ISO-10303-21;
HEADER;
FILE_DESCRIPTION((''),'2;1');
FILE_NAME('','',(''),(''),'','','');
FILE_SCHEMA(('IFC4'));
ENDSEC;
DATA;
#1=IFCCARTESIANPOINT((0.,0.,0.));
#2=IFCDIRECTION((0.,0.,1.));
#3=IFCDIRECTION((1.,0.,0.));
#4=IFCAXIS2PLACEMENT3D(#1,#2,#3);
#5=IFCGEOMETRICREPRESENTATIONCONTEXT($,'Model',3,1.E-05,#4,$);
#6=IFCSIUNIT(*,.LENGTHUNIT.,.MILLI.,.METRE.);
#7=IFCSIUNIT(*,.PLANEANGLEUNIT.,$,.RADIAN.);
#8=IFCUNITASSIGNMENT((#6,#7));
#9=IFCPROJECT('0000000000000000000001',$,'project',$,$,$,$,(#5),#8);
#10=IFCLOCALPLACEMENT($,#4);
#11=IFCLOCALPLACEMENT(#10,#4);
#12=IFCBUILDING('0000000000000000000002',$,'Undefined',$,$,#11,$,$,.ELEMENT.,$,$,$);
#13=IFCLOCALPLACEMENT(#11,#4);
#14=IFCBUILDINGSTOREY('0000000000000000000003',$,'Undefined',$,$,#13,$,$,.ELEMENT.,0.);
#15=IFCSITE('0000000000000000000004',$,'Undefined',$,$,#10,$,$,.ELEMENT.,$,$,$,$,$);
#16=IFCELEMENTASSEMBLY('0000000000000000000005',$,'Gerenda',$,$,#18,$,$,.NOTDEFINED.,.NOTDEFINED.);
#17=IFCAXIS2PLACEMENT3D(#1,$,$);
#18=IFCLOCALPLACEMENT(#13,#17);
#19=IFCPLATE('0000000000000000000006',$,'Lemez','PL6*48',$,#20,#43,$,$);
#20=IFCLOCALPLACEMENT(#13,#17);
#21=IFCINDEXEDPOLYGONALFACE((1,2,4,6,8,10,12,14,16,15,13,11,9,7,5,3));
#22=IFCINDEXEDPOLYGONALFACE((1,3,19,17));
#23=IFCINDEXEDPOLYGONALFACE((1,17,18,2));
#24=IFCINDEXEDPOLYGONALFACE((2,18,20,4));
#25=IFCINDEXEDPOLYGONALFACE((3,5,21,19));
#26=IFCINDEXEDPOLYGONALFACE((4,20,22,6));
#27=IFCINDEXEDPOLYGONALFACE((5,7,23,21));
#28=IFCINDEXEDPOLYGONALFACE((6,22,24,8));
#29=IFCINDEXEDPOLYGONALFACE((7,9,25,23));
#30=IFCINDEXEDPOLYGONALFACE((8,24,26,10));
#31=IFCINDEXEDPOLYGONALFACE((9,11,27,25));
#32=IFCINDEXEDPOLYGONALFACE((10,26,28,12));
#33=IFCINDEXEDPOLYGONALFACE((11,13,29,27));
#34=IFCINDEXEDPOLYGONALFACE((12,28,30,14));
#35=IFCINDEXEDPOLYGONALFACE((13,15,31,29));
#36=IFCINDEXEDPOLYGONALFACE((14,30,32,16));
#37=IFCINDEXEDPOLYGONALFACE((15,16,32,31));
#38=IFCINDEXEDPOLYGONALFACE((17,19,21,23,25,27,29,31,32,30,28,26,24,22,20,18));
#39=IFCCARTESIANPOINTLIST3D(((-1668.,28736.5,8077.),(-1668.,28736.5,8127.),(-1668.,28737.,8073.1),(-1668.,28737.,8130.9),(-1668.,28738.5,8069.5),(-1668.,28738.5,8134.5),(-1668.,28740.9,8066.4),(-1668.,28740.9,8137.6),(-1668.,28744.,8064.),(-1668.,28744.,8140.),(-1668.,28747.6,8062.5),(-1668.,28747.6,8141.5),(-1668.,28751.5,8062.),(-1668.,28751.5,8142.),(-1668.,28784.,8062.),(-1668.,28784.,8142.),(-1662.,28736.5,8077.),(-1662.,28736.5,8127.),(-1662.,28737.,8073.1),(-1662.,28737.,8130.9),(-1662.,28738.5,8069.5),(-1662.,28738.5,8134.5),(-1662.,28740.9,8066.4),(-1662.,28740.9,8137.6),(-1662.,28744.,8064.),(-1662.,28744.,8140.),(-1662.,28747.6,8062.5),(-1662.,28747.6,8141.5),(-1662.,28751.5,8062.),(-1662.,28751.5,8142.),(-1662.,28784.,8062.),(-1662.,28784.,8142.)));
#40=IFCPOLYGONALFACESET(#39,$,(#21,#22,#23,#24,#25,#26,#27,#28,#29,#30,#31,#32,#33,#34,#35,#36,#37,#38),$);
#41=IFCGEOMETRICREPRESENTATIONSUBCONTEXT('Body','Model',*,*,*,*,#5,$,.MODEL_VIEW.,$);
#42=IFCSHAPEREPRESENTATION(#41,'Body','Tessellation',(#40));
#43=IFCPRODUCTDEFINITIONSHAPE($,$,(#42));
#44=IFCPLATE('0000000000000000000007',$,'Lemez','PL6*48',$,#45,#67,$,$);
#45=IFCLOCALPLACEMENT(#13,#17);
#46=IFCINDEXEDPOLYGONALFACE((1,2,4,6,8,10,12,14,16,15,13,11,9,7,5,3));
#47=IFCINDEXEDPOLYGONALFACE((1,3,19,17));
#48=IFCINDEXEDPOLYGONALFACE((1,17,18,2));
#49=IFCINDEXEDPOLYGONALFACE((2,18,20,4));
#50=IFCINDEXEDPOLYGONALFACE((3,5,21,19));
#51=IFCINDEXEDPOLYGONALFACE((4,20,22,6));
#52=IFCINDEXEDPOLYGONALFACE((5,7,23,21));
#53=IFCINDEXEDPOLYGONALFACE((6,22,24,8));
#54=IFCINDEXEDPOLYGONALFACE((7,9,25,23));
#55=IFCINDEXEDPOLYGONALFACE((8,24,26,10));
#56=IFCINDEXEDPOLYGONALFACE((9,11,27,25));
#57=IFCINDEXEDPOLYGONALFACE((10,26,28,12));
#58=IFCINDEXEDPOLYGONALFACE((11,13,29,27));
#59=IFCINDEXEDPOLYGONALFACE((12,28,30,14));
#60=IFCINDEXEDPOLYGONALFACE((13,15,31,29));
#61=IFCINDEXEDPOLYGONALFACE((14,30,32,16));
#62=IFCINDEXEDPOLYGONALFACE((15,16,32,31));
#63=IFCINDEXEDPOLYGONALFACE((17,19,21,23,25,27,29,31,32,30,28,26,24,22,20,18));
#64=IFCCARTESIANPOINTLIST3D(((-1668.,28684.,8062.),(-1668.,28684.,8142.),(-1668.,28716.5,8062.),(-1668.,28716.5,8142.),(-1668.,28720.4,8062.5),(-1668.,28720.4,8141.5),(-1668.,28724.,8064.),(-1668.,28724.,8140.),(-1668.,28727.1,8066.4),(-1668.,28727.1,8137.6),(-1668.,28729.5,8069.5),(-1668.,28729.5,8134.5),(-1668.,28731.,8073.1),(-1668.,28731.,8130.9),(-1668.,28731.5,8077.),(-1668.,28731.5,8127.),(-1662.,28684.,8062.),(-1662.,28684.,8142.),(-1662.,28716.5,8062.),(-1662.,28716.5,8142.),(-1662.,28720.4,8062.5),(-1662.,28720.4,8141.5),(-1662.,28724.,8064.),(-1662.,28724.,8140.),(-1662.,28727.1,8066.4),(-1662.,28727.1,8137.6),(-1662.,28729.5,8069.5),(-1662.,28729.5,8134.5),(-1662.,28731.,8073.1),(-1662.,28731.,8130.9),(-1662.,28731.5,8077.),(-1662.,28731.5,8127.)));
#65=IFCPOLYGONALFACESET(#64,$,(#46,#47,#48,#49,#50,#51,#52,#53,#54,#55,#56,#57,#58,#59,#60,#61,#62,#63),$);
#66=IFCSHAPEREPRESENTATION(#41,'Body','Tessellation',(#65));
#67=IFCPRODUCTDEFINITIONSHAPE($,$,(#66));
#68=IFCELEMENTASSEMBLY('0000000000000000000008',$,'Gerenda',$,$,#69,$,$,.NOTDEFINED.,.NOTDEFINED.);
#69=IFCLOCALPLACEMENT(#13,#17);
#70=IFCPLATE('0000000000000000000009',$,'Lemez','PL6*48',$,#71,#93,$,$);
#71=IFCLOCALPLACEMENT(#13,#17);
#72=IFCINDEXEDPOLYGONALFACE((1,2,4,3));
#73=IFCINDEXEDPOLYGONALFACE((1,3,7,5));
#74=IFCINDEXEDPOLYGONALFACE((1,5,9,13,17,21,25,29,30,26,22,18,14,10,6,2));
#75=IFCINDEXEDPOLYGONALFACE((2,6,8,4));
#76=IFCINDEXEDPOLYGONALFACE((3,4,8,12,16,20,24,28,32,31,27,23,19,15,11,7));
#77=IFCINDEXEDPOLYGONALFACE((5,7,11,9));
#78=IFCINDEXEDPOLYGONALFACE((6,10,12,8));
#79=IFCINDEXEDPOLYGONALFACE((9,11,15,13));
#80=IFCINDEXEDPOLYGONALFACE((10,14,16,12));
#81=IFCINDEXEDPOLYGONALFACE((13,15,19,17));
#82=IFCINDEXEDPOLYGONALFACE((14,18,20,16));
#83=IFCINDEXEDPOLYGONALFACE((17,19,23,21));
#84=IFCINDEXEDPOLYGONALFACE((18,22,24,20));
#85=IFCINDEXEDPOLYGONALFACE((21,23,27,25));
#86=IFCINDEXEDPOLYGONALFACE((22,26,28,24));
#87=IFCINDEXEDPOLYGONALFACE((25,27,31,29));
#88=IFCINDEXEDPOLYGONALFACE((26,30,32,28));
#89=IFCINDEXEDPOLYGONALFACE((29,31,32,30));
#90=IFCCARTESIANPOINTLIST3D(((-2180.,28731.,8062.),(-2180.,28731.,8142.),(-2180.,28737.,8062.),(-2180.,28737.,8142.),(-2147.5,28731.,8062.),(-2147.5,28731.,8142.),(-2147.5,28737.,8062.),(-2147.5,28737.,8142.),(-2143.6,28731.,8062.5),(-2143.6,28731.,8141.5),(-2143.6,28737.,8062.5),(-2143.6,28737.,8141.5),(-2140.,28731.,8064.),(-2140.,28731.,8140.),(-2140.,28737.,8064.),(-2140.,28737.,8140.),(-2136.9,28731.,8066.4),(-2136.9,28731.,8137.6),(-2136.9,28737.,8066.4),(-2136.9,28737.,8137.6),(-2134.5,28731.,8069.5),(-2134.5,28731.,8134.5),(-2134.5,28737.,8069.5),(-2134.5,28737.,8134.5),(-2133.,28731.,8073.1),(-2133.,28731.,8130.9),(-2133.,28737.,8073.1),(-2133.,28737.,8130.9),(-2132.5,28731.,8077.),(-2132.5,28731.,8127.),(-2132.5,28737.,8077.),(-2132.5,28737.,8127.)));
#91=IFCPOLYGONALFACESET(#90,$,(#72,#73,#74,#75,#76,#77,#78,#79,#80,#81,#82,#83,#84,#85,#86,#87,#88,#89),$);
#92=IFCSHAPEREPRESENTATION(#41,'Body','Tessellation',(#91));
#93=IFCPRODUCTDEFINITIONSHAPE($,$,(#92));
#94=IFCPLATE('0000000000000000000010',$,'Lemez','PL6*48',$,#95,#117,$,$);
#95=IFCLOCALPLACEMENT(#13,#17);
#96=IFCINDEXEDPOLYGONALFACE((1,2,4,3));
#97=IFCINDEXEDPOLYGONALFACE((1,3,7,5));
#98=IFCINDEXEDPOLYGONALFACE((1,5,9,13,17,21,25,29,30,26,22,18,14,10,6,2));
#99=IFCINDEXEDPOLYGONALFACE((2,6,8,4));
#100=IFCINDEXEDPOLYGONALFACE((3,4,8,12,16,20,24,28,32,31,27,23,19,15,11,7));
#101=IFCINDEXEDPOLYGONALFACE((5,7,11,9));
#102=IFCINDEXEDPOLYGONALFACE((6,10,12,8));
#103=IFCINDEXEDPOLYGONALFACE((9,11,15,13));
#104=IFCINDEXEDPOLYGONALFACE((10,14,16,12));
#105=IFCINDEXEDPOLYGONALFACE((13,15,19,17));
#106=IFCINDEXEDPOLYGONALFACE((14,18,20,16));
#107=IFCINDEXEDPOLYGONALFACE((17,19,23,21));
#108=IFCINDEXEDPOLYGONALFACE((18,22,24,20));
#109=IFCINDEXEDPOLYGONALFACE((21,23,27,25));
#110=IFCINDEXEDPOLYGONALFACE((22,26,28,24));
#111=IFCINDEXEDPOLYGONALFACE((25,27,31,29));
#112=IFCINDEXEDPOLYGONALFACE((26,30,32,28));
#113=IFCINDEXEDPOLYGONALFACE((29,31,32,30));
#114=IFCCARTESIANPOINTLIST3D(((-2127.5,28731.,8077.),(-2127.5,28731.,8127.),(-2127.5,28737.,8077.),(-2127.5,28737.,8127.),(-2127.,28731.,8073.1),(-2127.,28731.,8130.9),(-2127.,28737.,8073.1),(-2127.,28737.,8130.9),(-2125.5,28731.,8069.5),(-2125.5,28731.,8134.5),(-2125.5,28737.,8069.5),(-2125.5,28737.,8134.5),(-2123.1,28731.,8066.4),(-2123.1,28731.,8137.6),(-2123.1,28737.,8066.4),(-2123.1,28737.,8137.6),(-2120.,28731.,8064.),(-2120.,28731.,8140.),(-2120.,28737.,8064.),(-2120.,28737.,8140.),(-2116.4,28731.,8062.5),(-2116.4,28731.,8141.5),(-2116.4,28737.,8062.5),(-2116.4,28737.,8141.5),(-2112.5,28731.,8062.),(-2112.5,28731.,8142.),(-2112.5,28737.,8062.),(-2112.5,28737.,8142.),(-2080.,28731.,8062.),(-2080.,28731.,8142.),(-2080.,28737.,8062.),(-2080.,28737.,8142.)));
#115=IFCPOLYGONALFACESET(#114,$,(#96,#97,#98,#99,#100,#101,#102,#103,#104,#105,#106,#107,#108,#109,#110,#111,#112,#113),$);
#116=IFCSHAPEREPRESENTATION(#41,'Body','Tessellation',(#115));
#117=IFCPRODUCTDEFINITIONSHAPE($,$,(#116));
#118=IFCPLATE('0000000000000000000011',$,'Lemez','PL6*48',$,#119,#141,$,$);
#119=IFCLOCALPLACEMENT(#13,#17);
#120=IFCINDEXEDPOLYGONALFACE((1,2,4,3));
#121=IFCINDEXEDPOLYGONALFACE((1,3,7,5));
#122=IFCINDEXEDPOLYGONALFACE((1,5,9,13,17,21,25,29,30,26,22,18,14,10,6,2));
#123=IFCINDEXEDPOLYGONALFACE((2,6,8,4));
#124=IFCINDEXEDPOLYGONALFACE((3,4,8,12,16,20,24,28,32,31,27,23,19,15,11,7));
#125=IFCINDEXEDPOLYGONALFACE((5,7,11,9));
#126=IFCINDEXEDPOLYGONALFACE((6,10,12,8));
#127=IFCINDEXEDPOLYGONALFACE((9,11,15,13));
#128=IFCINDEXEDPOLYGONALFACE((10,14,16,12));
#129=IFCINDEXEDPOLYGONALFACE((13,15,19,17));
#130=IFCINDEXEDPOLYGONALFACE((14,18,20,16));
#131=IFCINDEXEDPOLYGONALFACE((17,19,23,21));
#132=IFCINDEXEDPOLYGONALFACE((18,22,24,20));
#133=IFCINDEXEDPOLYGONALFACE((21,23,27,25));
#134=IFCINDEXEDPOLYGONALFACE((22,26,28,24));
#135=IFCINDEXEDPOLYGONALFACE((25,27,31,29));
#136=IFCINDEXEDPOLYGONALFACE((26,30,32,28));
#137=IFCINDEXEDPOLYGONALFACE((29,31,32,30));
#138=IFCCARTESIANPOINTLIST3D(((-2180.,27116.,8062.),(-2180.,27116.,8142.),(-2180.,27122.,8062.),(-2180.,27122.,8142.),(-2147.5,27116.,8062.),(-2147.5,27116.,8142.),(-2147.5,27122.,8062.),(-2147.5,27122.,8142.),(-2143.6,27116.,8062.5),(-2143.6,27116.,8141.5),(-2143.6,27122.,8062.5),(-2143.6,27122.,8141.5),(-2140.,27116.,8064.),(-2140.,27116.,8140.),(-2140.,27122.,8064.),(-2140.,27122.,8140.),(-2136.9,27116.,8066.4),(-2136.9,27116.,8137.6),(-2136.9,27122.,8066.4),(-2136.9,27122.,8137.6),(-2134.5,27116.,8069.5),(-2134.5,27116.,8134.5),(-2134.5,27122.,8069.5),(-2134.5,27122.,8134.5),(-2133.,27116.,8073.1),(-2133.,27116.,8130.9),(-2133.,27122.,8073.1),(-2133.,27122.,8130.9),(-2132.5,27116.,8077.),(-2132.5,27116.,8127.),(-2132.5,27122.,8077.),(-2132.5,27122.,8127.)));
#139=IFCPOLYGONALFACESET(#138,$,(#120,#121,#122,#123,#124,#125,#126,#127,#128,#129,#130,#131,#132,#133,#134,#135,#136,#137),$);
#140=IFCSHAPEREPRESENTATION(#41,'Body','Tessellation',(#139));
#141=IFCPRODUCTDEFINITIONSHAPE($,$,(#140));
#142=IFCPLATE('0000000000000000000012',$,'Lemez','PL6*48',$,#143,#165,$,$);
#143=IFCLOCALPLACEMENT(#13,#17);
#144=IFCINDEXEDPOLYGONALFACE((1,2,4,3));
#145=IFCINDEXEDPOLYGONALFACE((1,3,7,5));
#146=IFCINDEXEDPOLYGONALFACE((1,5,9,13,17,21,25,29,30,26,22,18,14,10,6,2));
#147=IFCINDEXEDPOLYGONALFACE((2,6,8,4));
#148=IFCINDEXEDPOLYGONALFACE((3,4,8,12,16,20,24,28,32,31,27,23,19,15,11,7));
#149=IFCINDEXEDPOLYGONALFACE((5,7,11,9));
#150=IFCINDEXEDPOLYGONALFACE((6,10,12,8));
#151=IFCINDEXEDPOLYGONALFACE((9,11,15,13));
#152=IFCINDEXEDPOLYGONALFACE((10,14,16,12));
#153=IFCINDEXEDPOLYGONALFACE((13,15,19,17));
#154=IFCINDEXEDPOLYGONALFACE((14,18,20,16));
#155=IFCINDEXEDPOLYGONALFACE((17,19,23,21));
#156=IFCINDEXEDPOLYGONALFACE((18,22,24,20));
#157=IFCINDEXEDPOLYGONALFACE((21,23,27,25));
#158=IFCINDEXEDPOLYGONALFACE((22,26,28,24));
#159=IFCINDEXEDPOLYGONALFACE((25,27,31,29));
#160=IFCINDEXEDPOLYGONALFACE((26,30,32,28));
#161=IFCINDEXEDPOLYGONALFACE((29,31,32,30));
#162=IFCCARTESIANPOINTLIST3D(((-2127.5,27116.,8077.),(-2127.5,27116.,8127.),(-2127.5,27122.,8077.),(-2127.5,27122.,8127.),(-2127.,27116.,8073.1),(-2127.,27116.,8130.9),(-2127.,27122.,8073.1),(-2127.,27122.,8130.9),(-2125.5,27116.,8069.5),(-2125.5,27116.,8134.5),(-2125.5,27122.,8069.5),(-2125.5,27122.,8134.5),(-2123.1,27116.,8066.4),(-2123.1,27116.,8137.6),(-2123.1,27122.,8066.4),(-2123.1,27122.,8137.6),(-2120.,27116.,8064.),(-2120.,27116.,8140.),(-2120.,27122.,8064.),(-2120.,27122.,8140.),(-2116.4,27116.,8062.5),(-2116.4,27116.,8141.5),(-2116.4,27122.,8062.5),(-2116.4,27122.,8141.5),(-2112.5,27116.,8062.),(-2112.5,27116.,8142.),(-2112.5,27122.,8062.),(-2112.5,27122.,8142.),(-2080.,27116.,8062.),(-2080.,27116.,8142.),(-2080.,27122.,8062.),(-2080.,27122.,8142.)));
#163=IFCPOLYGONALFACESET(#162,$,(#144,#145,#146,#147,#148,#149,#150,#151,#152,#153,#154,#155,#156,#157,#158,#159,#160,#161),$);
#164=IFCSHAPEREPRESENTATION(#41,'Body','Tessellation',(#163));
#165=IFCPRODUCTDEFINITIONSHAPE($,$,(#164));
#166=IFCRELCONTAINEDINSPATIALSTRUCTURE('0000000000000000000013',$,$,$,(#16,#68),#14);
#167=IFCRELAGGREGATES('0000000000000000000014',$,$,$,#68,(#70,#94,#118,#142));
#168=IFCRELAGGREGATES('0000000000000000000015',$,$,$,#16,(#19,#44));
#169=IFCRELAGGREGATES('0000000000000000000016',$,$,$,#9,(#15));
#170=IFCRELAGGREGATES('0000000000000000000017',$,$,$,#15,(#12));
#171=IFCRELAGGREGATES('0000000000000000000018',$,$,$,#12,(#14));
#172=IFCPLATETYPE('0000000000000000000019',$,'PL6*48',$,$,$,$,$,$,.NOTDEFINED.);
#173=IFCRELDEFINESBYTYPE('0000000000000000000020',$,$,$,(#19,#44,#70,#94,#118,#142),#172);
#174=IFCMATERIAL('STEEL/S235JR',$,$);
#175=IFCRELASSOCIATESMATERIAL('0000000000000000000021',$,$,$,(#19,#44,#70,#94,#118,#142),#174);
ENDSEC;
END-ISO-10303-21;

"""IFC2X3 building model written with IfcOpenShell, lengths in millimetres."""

from ifc_helpers import new_model, si_unit, frame, frame_2d, origin_with_axes, place, context, subcontext, project, spatial, polyline, circle_curve, parameter, trimmed, segment, composite_curve, outline, extrude, material, type_object, element, aggregate, save


model = new_model("IFC2X3")

# Units and contexts
model_context = context("Model", 3, precision=1e-05, world=origin_with_axes())
body_context = subcontext(model_context, "Body", "Model", "MODEL_VIEW")
ifc_project = project(units=[si_unit("LENGTHUNIT", "METRE", prefix="MILLI"), si_unit("PLANEANGLEUNIT", "RADIAN")], contexts=[model_context])

# Site, building, storey
site_placement = place(None, origin_with_axes())
site = spatial("IfcSite", under=ifc_project, at=site_placement, Name="Undefined", CompositionType="ELEMENT")
building_placement = place(site_placement, origin_with_axes())
building = spatial("IfcBuilding", under=site, at=building_placement, Name="Undefined", CompositionType="ELEMENT")
storey_placement = place(building_placement, origin_with_axes())
storey = spatial("IfcBuildingStorey", under=building, at=storey_placement, Name="Undefined", CompositionType="ELEMENT", Elevation=0.0)

# Element assemblies, plates
ifc_material = material(Name="STEEL/S235JR")
plate_type_1 = type_object("IfcPlateType", Name="PL6*48", PredefinedType="NOTDEFINED")
assembly_1_placement = place(storey_placement, origin_with_axes())
assembly_1 = element("IfcElementAssembly", 1, at=assembly_1_placement, inside=storey, Name="Gerenda", AssemblyPlace="NOTDEFINED", PredefinedType="NOTDEFINED")
plate_1_placement = place(assembly_1_placement, frame((-1665.0, 28736.5, 8062.0), z_axis=(1.0, -0.000003, 0.0), x_axis=(0.000003, 1.0, 0.0)))
plate_1 = element("IfcPlate", 2, at=plate_1_placement, type_object=plate_type_1, material=ifc_material, Name="Lemez", Description="PL6*48", context=body_context, shape_type="SweptSolid", body=[
    extrude(outline(composite_curve([segment(trimmed(circle_curve(frame_2d((15.0, 15.0), x_axis=(-1.0, 0.0)), 15.0), [parameter(0.0)], [parameter(1.570796)], True, "PARAMETER"), True, "CONTINUOUS"), segment(polyline([(15.0, 0.0), (47.5, 0.0), (47.5, 80.0), (15.0, 80.0)]), True, "CONTINUOUS"), segment(trimmed(circle_curve(frame_2d((15.0, 65.0), x_axis=(0.0, 1.0)), 15.0), [parameter(0.0)], [parameter(1.570796)], True, "PARAMETER"), True, "CONTINUOUS"), segment(polyline([(0.0, 65.0), (0.0, 15.0)]), True, "CONTINUOUS")], self_intersect=True)), frame((0.0, 0.0, -3.0), z_axis=(0.0, 0.0, 1.0), x_axis=(1.0, 0.0, 0.0)), (0.0, 0.0, 1.0), 6.0),
])
plate_2_placement = place(assembly_1_placement, frame((-1665.0, 28731.5, 8062.0), z_axis=(-1.0, 0.000003, 0.0), x_axis=(-0.000003, -1.0, 0.0)))
plate_2 = element("IfcPlate", 3, at=plate_2_placement, type_object=plate_type_1, material=ifc_material, Name="Lemez", Description="PL6*48", context=body_context, shape_type="SweptSolid", body=[
    extrude(outline(composite_curve([segment(trimmed(circle_curve(frame_2d((15.0, 15.0), x_axis=(-1.0, 0.0)), 15.0), [parameter(0.0)], [parameter(1.570796)], True, "PARAMETER"), True, "CONTINUOUS"), segment(polyline([(15.0, 0.0), (47.5, 0.0), (47.5, 80.0), (15.0, 80.0)]), True, "CONTINUOUS"), segment(trimmed(circle_curve(frame_2d((15.0, 65.0), x_axis=(0.0, 1.0)), 15.0), [parameter(0.0)], [parameter(1.570796)], True, "PARAMETER"), True, "CONTINUOUS"), segment(polyline([(0.0, 65.0), (0.0, 15.0)]), True, "CONTINUOUS")], self_intersect=True)), frame((0.0, 0.0, -3.0), z_axis=(0.0, 0.0, 1.0), x_axis=(1.0, 0.0, 0.0)), (0.0, 0.0, 1.0), 6.0),
])
assembly_2_placement = place(storey_placement, origin_with_axes())
assembly_2 = element("IfcElementAssembly", 4, at=assembly_2_placement, inside=storey, Name="Gerenda", AssemblyPlace="NOTDEFINED", PredefinedType="NOTDEFINED")
plate_3_placement = place(assembly_2_placement, frame((-2132.5, 28734.0, 8062.0), z_axis=(0.000004, 1.0, 0.0), x_axis=(-1.0, 0.000004, 0.0)))
plate_3 = element("IfcPlate", 5, at=plate_3_placement, type_object=plate_type_1, material=ifc_material, Name="Lemez", Description="PL6*48", context=body_context, shape_type="SweptSolid", body=[
    extrude(outline(composite_curve([segment(trimmed(circle_curve(frame_2d((15.0, 15.0), x_axis=(-1.0, 0.0)), 15.0), [parameter(0.0)], [parameter(1.570796)], True, "PARAMETER"), True, "CONTINUOUS"), segment(polyline([(15.0, 0.0), (47.5, 0.0), (47.5, 80.0), (15.0, 80.0)]), True, "CONTINUOUS"), segment(trimmed(circle_curve(frame_2d((15.0, 65.0), x_axis=(0.0, 1.0)), 15.0), [parameter(0.0)], [parameter(1.570796)], True, "PARAMETER"), True, "CONTINUOUS"), segment(polyline([(0.0, 65.0), (0.0, 15.0)]), True, "CONTINUOUS")], self_intersect=True)), frame((0.0, 0.0, -3.0), z_axis=(0.0, 0.0, 1.0), x_axis=(1.0, 0.0, 0.0)), (0.0, 0.0, 1.0), 6.0),
])
plate_4_placement = place(assembly_2_placement, frame((-2127.5, 28734.0, 8062.0), z_axis=(-0.000004, -1.0, 0.0), x_axis=(1.0, -0.000004, 0.0)))
plate_4 = element("IfcPlate", 6, at=plate_4_placement, type_object=plate_type_1, material=ifc_material, Name="Lemez", Description="PL6*48", context=body_context, shape_type="SweptSolid", body=[
    extrude(outline(composite_curve([segment(trimmed(circle_curve(frame_2d((15.0, 15.0), x_axis=(-1.0, 0.0)), 15.0), [parameter(0.0)], [parameter(1.570796)], True, "PARAMETER"), True, "CONTINUOUS"), segment(polyline([(15.0, 0.0), (47.5, 0.0), (47.5, 80.0), (15.0, 80.0)]), True, "CONTINUOUS"), segment(trimmed(circle_curve(frame_2d((15.0, 65.0), x_axis=(0.0, 1.0)), 15.0), [parameter(0.0)], [parameter(1.570796)], True, "PARAMETER"), True, "CONTINUOUS"), segment(polyline([(0.0, 65.0), (0.0, 15.0)]), True, "CONTINUOUS")], self_intersect=True)), frame((0.0, 0.0, -3.0), z_axis=(0.0, 0.0, 1.0), x_axis=(1.0, 0.0, 0.0)), (0.0, 0.0, 1.0), 6.0),
])
plate_5_placement = place(assembly_2_placement, frame((-2132.5, 27119.0, 8062.0), z_axis=(0.000004, 1.0, 0.0), x_axis=(-1.0, 0.000004, 0.0)))
plate_5 = element("IfcPlate", 7, at=plate_5_placement, type_object=plate_type_1, material=ifc_material, Name="Lemez", Description="PL6*48", context=body_context, shape_type="SweptSolid", body=[
    extrude(outline(composite_curve([segment(trimmed(circle_curve(frame_2d((15.0, 15.0), x_axis=(-1.0, 0.0)), 15.0), [parameter(0.0)], [parameter(1.570796)], True, "PARAMETER"), True, "CONTINUOUS"), segment(polyline([(15.0, 0.0), (47.5, 0.0), (47.5, 80.0), (15.0, 80.0)]), True, "CONTINUOUS"), segment(trimmed(circle_curve(frame_2d((15.0, 65.0), x_axis=(0.0, 1.0)), 15.0), [parameter(0.0)], [parameter(1.570796)], True, "PARAMETER"), True, "CONTINUOUS"), segment(polyline([(0.0, 65.0), (0.0, 15.0)]), True, "CONTINUOUS")], self_intersect=True)), frame((0.0, 0.0, -3.0), z_axis=(0.0, 0.0, 1.0), x_axis=(1.0, 0.0, 0.0)), (0.0, 0.0, 1.0), 6.0),
])
plate_6_placement = place(assembly_2_placement, frame((-2127.5, 27119.0, 8062.0), z_axis=(-0.000004, -1.0, 0.0), x_axis=(1.0, -0.000004, 0.0)))
plate_6 = element("IfcPlate", 8, at=plate_6_placement, type_object=plate_type_1, material=ifc_material, Name="Lemez", Description="PL6*48", context=body_context, shape_type="SweptSolid", body=[
    extrude(outline(composite_curve([segment(trimmed(circle_curve(frame_2d((15.0, 15.0), x_axis=(-1.0, 0.0)), 15.0), [parameter(0.0)], [parameter(1.570796)], True, "PARAMETER"), True, "CONTINUOUS"), segment(polyline([(15.0, 0.0), (47.5, 0.0), (47.5, 80.0), (15.0, 80.0)]), True, "CONTINUOUS"), segment(trimmed(circle_curve(frame_2d((15.0, 65.0), x_axis=(0.0, 1.0)), 15.0), [parameter(0.0)], [parameter(1.570796)], True, "PARAMETER"), True, "CONTINUOUS"), segment(polyline([(0.0, 65.0), (0.0, 15.0)]), True, "CONTINUOUS")], self_intersect=True)), frame((0.0, 0.0, -3.0), z_axis=(0.0, 0.0, 1.0), x_axis=(1.0, 0.0, 0.0)), (0.0, 0.0, 1.0), 6.0),
])

aggregate(assembly_2, [plate_3, plate_4, plate_5, plate_6])
aggregate(assembly_1, [plate_1, plate_2])

save(model, "model.ifc")
